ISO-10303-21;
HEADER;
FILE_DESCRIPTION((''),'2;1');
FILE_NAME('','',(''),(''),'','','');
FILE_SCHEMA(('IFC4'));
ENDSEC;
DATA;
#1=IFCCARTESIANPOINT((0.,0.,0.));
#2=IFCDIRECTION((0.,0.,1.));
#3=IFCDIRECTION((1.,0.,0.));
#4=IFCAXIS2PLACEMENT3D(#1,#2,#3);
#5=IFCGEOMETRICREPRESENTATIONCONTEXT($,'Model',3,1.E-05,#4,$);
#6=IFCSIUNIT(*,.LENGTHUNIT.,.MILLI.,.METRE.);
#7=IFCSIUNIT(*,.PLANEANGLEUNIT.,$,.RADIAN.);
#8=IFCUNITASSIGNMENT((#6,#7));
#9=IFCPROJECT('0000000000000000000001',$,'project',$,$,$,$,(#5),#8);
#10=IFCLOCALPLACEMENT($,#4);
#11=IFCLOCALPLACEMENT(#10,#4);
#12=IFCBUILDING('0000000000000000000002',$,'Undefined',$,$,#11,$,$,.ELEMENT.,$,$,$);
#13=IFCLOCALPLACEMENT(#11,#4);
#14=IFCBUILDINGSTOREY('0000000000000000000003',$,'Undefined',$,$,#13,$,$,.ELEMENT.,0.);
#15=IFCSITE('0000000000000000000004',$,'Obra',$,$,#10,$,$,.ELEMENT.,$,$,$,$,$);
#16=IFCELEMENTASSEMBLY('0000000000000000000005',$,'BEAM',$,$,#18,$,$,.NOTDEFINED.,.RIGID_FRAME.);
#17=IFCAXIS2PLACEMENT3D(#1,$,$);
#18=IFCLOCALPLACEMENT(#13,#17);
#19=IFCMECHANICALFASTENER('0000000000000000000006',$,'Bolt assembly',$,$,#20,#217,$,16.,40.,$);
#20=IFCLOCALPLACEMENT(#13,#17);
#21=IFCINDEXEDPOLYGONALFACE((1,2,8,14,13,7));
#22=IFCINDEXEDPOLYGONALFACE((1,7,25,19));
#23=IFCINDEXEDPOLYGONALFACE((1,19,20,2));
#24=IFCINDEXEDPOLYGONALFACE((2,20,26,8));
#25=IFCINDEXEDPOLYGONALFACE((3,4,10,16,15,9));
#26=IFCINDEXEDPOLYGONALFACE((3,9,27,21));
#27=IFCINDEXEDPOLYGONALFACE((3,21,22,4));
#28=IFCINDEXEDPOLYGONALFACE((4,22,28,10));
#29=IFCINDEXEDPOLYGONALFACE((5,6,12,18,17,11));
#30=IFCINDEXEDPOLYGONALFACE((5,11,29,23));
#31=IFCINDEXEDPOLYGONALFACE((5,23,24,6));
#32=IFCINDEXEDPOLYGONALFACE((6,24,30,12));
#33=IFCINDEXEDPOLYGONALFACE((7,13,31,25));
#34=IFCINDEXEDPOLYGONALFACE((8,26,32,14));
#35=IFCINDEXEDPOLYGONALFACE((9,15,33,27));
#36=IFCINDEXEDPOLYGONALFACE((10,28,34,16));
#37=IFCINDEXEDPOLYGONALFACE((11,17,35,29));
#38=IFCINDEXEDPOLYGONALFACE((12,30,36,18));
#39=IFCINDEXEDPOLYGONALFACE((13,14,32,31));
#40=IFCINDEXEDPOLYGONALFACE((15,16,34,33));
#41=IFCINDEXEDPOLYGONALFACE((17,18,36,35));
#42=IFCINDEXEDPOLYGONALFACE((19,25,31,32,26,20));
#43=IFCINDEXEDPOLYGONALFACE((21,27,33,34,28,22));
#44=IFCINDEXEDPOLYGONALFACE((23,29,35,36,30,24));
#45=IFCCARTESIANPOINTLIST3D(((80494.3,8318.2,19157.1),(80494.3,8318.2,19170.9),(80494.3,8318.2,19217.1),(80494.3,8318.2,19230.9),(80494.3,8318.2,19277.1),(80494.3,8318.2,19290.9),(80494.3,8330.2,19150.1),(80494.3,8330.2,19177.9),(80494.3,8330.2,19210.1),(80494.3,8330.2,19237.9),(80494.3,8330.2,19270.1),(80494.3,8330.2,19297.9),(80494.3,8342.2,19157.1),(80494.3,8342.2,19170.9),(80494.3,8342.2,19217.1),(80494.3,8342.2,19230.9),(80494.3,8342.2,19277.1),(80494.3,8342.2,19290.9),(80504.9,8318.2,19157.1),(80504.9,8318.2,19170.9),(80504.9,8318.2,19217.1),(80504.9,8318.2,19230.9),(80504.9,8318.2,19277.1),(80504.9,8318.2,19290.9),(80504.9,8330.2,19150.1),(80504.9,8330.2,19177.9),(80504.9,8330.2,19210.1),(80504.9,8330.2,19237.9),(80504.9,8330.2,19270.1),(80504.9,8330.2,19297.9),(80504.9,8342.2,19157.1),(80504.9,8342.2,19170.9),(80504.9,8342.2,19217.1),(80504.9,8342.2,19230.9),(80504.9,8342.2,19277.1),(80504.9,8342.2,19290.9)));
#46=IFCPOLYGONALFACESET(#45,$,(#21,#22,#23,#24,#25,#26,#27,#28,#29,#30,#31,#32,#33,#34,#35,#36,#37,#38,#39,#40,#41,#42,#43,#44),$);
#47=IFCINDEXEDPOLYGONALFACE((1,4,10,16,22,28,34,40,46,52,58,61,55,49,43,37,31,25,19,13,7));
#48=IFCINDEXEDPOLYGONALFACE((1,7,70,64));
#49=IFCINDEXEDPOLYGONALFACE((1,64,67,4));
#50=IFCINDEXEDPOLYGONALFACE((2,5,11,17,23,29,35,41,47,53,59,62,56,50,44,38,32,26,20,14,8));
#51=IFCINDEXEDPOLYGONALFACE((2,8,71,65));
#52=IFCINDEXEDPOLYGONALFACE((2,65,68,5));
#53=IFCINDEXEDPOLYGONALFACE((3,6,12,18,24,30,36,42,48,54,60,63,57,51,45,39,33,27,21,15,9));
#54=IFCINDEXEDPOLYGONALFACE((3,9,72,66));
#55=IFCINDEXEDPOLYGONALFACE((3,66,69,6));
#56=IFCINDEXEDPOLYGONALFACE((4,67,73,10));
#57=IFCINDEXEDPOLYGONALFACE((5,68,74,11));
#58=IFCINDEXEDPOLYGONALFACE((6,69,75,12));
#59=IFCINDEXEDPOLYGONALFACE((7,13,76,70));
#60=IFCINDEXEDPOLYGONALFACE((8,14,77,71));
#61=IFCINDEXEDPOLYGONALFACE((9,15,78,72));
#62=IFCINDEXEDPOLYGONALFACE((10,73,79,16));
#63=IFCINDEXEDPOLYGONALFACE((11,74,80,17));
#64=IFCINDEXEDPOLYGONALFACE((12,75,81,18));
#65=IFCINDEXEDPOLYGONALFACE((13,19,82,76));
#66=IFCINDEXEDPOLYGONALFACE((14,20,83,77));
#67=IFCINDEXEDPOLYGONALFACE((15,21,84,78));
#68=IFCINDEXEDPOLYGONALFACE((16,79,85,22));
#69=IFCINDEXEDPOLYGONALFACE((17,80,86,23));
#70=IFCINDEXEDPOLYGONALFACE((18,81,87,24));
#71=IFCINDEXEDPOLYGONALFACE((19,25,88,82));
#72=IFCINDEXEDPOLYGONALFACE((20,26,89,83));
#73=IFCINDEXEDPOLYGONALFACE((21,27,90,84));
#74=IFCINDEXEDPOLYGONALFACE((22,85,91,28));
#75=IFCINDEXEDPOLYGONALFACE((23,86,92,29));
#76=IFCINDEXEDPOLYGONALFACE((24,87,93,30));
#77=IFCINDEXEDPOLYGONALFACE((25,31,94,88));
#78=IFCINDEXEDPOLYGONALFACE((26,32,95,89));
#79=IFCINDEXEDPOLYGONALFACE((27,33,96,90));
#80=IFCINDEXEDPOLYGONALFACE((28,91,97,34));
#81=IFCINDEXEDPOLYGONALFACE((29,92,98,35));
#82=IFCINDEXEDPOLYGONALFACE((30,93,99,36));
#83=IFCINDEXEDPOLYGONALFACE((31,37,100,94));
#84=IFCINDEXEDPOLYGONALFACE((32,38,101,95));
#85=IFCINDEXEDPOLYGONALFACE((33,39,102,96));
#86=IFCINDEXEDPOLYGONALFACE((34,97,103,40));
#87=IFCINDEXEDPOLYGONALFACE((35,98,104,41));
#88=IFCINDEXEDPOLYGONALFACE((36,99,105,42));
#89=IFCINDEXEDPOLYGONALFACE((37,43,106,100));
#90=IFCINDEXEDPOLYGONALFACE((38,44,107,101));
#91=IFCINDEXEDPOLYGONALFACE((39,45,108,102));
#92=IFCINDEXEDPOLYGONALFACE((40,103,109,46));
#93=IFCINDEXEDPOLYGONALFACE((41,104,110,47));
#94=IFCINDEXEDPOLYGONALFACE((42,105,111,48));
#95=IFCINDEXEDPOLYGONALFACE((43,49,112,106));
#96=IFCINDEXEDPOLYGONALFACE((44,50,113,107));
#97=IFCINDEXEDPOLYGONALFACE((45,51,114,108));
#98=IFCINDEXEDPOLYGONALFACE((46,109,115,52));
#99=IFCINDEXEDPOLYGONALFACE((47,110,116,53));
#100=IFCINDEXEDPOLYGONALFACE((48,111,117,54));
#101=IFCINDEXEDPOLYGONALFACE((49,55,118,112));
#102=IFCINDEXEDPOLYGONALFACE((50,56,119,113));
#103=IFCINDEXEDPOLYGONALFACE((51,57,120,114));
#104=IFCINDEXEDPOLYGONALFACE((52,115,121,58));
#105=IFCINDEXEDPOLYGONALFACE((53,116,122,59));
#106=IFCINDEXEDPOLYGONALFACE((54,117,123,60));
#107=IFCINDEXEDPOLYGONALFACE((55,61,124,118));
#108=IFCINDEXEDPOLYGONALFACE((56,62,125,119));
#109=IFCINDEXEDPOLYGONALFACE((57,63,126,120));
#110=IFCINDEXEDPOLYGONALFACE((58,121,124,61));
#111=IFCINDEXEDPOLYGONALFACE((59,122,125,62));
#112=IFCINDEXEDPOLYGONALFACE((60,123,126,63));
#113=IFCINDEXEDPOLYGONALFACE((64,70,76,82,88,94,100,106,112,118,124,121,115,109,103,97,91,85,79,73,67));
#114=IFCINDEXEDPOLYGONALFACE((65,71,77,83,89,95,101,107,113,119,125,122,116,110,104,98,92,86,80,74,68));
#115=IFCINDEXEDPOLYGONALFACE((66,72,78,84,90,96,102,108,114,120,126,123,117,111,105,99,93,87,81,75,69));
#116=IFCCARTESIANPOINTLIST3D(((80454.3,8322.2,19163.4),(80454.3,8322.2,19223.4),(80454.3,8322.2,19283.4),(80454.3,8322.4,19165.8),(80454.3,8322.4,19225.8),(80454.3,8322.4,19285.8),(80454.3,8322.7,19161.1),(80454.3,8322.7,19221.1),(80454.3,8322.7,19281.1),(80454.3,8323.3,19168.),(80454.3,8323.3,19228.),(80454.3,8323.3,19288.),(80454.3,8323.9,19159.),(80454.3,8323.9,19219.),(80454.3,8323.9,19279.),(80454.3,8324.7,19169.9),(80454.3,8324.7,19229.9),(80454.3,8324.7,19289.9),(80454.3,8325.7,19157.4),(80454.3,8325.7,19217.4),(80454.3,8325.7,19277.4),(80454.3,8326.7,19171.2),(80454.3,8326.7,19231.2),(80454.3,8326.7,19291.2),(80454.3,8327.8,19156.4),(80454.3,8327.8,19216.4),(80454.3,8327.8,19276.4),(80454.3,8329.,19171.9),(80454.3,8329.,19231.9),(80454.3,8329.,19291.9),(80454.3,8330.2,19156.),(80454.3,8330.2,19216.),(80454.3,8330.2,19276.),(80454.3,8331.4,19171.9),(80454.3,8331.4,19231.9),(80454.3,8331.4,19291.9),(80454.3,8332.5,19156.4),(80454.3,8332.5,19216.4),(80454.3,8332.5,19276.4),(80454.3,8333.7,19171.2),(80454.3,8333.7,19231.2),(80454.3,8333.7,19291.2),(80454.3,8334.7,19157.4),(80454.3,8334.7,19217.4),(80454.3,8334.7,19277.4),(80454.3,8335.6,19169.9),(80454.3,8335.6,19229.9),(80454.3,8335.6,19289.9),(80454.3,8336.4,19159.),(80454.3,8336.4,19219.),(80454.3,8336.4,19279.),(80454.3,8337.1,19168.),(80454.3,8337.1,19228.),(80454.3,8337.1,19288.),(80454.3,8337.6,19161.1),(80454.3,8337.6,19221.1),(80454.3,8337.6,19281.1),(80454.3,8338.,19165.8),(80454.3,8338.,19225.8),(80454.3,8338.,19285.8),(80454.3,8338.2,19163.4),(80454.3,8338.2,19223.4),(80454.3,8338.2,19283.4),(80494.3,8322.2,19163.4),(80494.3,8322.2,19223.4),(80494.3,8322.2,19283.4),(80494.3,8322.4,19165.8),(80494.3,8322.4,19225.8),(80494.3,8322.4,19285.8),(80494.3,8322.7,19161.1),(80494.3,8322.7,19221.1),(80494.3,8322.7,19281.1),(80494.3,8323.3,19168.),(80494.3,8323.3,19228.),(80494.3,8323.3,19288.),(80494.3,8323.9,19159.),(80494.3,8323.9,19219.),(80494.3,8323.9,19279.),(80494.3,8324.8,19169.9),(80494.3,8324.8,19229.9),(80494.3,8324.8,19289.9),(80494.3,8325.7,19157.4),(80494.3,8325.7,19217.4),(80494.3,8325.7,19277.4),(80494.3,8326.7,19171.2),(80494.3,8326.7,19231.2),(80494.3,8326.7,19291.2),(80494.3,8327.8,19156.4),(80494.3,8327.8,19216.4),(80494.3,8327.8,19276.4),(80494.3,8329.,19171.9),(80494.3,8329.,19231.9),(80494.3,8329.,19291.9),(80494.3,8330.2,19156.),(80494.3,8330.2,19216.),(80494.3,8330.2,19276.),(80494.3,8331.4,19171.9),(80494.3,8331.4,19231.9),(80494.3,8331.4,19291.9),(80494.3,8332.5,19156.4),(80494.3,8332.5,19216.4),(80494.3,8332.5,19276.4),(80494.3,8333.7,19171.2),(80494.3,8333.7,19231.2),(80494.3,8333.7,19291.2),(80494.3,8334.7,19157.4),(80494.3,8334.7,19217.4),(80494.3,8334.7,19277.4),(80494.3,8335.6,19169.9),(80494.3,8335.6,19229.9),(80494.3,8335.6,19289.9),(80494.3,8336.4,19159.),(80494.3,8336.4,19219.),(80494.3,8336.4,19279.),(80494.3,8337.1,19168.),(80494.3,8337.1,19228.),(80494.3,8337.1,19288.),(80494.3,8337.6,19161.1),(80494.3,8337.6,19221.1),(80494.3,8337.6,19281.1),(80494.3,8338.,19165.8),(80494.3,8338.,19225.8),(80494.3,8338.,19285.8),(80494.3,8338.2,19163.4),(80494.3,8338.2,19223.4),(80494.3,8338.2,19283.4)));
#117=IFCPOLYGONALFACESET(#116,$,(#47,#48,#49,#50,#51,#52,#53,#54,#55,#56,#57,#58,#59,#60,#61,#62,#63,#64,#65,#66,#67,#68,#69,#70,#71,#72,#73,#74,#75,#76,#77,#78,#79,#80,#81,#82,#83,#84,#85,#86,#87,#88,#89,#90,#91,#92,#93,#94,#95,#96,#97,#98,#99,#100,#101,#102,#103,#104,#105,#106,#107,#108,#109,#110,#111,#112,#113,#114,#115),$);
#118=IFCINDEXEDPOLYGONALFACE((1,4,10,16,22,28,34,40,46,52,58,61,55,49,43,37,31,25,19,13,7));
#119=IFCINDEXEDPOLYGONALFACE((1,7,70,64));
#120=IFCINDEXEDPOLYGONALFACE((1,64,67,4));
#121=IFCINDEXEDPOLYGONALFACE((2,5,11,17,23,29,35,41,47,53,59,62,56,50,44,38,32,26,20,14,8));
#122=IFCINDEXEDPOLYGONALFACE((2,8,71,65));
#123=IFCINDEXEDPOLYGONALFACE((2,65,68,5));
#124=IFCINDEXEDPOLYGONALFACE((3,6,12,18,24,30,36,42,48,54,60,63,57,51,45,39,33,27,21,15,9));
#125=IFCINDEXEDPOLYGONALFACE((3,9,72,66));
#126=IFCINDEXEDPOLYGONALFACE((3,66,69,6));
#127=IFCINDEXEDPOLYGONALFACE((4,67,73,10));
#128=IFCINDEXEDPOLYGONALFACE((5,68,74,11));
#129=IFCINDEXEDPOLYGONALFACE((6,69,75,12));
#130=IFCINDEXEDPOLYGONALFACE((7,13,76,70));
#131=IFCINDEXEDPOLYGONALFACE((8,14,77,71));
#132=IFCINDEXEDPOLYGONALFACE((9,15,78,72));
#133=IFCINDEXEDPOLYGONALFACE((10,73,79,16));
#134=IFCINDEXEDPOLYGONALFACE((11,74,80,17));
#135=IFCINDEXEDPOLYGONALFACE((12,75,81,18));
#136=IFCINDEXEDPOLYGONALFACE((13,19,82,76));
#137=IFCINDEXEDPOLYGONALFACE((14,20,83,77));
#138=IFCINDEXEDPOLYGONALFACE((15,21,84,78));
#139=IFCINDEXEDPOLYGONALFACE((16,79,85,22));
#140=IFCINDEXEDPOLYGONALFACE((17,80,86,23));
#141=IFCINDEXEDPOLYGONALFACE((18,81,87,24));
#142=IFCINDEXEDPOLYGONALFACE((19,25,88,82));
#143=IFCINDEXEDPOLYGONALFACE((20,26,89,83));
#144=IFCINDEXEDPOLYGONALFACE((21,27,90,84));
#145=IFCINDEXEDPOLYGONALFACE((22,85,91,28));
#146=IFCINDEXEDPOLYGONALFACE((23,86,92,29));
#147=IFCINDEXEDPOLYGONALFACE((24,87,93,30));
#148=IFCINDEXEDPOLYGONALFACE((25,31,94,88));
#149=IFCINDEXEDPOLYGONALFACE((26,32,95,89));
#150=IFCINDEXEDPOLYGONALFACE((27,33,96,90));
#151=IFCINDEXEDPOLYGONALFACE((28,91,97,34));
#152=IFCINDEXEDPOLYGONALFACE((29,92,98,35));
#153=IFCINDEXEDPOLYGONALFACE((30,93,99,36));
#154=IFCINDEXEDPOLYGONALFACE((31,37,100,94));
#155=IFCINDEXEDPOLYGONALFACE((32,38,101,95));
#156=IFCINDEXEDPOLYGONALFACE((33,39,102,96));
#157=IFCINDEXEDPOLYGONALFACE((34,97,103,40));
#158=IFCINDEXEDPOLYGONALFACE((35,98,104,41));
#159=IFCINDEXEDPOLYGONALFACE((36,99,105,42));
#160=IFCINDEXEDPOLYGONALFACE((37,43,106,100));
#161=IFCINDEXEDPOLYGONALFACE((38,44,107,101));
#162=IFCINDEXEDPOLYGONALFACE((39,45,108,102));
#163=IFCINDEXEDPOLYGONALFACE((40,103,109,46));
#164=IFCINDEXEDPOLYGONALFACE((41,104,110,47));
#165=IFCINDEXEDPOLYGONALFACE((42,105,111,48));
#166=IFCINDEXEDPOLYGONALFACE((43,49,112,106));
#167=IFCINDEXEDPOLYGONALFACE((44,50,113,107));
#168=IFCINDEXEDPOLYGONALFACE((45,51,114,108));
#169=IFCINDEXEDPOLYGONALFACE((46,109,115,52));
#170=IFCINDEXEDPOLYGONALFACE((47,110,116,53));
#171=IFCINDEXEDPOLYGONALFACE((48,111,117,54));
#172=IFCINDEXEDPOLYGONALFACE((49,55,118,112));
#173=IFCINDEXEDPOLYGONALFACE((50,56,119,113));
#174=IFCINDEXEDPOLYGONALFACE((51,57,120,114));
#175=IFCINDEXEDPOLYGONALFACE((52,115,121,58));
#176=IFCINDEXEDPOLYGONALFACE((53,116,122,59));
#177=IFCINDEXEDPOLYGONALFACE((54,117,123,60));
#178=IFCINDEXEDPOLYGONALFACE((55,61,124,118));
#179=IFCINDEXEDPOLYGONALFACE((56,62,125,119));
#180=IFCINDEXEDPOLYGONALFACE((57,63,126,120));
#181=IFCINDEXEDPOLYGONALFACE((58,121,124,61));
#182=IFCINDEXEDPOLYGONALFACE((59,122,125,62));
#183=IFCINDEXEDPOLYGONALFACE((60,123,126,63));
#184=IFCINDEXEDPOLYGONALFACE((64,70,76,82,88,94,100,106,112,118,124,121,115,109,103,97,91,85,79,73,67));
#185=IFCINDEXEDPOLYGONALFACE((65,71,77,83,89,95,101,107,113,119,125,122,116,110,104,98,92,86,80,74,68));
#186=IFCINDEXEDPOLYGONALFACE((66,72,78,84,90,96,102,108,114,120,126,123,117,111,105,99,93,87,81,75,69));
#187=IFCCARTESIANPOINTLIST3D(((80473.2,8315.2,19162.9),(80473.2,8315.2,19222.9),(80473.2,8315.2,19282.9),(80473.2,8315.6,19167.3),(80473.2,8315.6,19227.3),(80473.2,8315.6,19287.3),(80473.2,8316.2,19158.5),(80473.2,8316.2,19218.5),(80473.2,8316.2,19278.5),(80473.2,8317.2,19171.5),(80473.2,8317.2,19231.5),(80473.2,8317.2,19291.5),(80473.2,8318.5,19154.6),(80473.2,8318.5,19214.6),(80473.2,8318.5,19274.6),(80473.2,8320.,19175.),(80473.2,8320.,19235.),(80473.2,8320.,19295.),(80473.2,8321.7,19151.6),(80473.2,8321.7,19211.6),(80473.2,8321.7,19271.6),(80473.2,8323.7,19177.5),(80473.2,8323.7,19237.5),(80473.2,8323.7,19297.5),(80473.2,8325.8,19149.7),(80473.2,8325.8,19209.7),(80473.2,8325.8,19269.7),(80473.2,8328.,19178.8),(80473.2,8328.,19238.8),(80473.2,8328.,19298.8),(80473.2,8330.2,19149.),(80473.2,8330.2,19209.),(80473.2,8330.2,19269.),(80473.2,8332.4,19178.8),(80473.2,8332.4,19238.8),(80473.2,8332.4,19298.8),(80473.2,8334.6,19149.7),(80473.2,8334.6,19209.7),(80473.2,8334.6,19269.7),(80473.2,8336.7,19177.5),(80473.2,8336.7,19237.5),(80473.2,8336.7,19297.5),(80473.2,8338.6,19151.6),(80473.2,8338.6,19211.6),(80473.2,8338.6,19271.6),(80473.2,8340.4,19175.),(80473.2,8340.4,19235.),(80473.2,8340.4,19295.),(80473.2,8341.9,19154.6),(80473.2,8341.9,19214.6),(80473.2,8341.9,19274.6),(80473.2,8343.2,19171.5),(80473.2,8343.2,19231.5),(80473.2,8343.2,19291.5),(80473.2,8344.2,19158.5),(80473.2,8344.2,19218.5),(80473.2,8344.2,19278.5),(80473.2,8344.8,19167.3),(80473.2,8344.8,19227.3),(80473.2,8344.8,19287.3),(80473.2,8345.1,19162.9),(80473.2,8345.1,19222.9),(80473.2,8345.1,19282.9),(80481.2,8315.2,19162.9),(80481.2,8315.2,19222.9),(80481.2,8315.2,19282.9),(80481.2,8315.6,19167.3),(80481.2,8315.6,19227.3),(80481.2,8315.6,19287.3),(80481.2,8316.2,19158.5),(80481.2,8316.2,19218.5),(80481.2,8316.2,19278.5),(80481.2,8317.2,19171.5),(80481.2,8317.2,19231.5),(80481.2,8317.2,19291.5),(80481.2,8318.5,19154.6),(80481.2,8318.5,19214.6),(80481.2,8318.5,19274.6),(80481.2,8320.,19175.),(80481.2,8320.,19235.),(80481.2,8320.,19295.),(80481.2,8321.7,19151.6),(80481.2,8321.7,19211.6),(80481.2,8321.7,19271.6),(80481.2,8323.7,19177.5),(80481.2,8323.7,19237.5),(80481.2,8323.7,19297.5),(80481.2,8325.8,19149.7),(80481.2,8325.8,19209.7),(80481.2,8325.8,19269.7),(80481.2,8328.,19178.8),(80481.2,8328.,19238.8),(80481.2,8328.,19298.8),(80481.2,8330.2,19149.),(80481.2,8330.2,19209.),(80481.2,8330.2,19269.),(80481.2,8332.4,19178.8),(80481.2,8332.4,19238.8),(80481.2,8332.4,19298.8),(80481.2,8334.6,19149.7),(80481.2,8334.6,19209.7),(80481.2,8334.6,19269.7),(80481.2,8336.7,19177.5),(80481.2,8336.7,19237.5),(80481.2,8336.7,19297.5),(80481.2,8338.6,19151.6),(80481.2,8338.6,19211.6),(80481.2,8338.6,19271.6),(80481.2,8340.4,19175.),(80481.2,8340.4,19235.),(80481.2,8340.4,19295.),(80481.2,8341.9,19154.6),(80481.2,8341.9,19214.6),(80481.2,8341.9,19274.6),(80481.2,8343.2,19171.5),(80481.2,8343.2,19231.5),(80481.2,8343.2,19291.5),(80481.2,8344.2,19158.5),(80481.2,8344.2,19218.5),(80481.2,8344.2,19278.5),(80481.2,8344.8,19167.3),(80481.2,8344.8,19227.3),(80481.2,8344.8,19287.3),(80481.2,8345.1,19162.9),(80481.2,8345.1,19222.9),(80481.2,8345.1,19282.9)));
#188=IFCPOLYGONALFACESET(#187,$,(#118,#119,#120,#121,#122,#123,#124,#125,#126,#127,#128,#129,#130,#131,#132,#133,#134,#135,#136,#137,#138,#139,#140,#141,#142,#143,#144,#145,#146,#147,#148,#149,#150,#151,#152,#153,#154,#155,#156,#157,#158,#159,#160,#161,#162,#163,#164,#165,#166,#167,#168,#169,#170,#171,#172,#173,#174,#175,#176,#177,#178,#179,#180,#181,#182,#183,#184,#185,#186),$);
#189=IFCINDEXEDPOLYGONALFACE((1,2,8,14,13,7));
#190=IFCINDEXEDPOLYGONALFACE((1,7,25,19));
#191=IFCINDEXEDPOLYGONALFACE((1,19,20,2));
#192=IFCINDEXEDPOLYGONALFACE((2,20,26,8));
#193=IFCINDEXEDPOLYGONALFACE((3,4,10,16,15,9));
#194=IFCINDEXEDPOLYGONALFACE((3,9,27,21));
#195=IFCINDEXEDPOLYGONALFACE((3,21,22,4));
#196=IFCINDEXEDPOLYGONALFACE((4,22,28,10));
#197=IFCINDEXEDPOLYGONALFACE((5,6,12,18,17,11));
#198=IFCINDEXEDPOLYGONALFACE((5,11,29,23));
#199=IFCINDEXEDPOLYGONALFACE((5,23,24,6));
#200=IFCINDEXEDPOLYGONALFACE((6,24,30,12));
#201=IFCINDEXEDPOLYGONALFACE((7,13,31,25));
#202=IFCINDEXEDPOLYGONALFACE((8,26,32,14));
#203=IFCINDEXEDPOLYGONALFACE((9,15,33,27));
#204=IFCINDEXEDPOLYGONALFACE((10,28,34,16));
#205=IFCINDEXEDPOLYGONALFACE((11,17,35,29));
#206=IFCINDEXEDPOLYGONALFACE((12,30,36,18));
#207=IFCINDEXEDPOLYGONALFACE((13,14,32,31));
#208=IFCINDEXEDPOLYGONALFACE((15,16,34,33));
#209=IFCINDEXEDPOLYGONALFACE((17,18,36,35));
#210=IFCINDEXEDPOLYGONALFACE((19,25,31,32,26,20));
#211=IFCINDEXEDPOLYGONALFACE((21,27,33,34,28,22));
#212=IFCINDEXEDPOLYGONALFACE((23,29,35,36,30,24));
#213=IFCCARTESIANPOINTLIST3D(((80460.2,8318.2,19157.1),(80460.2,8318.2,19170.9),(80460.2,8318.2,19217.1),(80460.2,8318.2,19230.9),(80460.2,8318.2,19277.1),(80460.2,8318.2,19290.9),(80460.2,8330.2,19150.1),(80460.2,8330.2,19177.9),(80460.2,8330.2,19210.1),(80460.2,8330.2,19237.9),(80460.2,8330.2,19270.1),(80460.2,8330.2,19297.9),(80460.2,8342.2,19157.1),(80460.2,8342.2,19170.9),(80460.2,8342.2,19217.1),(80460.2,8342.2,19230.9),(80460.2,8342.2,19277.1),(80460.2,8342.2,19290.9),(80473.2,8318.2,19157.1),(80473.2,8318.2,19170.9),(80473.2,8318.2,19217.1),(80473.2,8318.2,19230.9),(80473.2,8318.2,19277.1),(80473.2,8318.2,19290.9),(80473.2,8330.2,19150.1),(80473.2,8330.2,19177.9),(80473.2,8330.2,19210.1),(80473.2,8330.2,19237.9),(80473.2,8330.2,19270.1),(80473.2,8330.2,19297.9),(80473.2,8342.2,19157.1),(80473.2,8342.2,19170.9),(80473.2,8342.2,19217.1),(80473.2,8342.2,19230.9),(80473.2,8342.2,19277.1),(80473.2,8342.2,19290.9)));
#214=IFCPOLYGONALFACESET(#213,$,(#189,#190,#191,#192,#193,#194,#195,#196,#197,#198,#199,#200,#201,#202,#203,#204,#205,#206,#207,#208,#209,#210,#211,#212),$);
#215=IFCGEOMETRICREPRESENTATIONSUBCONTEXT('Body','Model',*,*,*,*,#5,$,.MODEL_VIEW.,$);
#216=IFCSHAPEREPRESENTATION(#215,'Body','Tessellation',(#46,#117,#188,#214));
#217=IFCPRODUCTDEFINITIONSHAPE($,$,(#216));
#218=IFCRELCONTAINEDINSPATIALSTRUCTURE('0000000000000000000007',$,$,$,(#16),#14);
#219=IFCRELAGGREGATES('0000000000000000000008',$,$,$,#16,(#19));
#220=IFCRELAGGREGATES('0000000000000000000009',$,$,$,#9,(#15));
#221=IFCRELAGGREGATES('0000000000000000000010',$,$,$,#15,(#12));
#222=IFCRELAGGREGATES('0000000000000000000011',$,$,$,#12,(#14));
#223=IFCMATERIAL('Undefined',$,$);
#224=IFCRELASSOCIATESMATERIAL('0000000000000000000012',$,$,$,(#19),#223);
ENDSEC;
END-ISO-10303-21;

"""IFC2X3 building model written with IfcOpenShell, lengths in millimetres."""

from ifc_helpers import new_model, si_unit, frame, origin_with_axes, origin_2d_with_axis, place, context, subcontext, project, spatial, polyline, circle, outline, extrude, source, transform, mapped, material, element, aggregate, save


model = new_model("IFC2X3")

# Units and contexts
model_context = context("Model", 3, precision=1e-05, world=origin_with_axes())
body_context = subcontext(model_context, "Body", "Model", "MODEL_VIEW")
ifc_project = project(units=[si_unit("LENGTHUNIT", "METRE", prefix="MILLI"), si_unit("PLANEANGLEUNIT", "RADIAN")], contexts=[model_context])

# Site, building, storey
site_placement = place(None, origin_with_axes())
site = spatial("IfcSite", under=ifc_project, at=site_placement, Name="Obra", CompositionType="ELEMENT")
building_placement = place(site_placement, origin_with_axes())
building = spatial("IfcBuilding", under=site, at=building_placement, Name="Undefined", CompositionType="ELEMENT")
storey_placement = place(building_placement, origin_with_axes())
storey = spatial("IfcBuildingStorey", under=building, at=storey_placement, Name="Undefined", CompositionType="ELEMENT", Elevation=0.0)

# Shared definitions
ifc_material_1 = material(Name="Undefined")

# Element assembly, mechanical fastener
assembly_1_placement = place(storey_placement, origin_with_axes())
assembly_1 = element("IfcElementAssembly", 1, at=assembly_1_placement, inside=storey, Name="BEAM", AssemblyPlace="NOTDEFINED", PredefinedType="RIGID_FRAME")
shared_shape_1 = source(origin_with_axes(), body_context, "Body", "SweptSolid", [
    extrude(outline(polyline([(13.9, 0.0), (6.9, 12.0), (-6.9, 12.0), (-13.9, 0.0), (-6.9, -12.0), (6.9, -12.0), (13.9, 0.0)])), frame((0.0, -14.1, 0.0), z_axis=(0.0, 1.0, 0.0), x_axis=(1.0, 0.0, 0.0)), (0.0, 0.0, 1.0), 10.6),
    extrude(circle(Radius=8.0, at=origin_2d_with_axis()), frame((0.0, -3.6, 0.0), z_axis=(0.0, 1.0, 0.0), x_axis=(1.0, 0.0, 0.0)), (0.0, 0.0, 1.0), 40.0),
    extrude(circle(Radius=15.0, at=origin_2d_with_axis()), frame((0.0, 9.5, 0.0), z_axis=(0.0, 1.0, 0.0), x_axis=(1.0, 0.0, 0.0)), (0.0, 0.0, 1.0), 8.0),
    extrude(outline(polyline([(13.9, 0.0), (6.9, 12.0), (-6.9, 12.0), (-13.9, 0.0), (-6.9, -12.0), (6.9, -12.0), (13.9, 0.0)])), frame((0.0, 17.5, 0.0), z_axis=(0.0, 1.0, 0.0), x_axis=(1.0, 0.0, 0.0)), (0.0, 0.0, 1.0), 13.0),
])
mechanical_fastener_1_placement = place(assembly_1_placement, frame((80490.8, 8280.2, 19319.0), z_axis=(-0.000014, 1.0, 0.0), x_axis=(0.0, 0.0, -1.0)))
mechanical_fastener_1 = element("IfcMechanicalFastener", 2, at=mechanical_fastener_1_placement, material=ifc_material_1, Name="Bolt assembly", NominalDiameter=16.0, NominalLength=40.0, context=body_context, shape_type="MappedRepresentation", body=[
    mapped(shared_shape_1, transform((35.0, 0.0, 50.0))),
    mapped(shared_shape_1, transform((95.0, 0.0, 50.0))),
    mapped(shared_shape_1, transform((155.0, 0.0, 50.0))),
])
aggregate(assembly_1, [mechanical_fastener_1])

save(model, "model.ifc")
